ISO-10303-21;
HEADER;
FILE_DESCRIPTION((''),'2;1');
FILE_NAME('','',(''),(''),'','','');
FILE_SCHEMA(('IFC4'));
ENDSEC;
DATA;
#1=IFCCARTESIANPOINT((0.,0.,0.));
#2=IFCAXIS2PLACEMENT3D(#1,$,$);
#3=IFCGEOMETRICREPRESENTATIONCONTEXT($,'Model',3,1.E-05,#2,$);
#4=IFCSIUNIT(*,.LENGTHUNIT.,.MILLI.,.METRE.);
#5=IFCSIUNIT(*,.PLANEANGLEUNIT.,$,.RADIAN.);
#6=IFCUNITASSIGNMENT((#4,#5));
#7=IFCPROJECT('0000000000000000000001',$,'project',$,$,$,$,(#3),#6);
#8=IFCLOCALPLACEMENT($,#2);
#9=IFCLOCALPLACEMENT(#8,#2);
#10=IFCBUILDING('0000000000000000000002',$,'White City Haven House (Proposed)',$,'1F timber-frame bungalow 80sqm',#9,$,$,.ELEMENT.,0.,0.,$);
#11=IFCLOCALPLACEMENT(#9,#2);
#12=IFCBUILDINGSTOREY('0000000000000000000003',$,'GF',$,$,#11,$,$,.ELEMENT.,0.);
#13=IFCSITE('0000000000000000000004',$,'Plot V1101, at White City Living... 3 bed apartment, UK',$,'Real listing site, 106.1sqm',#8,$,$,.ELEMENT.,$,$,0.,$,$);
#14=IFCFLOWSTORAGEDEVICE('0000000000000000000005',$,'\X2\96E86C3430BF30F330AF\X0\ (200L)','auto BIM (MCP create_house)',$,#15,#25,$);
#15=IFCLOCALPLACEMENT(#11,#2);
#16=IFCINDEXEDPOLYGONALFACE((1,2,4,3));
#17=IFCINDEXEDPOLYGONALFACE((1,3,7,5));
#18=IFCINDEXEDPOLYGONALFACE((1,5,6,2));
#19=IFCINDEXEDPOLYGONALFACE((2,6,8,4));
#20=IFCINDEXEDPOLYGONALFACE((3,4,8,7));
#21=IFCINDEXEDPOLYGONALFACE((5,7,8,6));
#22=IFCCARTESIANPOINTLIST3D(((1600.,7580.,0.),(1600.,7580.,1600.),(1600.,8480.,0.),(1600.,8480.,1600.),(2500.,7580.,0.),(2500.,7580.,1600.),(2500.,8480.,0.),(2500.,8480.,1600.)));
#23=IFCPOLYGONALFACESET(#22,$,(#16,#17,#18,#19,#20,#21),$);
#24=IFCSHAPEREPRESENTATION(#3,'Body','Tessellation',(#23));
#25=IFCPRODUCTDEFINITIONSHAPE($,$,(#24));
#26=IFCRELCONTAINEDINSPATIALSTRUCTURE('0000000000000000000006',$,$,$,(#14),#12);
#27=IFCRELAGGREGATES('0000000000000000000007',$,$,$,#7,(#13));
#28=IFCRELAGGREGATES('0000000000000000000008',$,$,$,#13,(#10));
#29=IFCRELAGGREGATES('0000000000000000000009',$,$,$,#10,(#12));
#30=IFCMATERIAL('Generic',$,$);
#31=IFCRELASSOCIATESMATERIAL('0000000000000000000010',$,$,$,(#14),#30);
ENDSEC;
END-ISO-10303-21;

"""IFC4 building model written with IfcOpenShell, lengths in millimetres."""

from ifc_helpers import new_model, si_unit, frame, frame_2d, origin, place, context, project, spatial, rectangle, extrude, material, element, save


model = new_model("IFC4")

# Units and contexts
model_context = context("Model", 3, precision=1e-05, world=origin())
ifc_project = project(units=[si_unit("LENGTHUNIT", "METRE", prefix="MILLI"), si_unit("PLANEANGLEUNIT", "RADIAN")], contexts=[model_context])

# Site, building, storey
site_placement = place(None, origin())
site = spatial("IfcSite", under=ifc_project, at=site_placement, Name="Plot V1101, at White City Living... 3 bed apartment, UK", ObjectType="Real listing site, 106.1sqm", CompositionType="ELEMENT", RefElevation=0.0)
building_placement = place(site_placement, origin())
building = spatial("IfcBuilding", under=site, at=building_placement, Name="White City Haven House (Proposed)", ObjectType="1F timber-frame bungalow 80sqm", CompositionType="ELEMENT", ElevationOfRefHeight=0.0, ElevationOfTerrain=0.0)
storey_placement = place(building_placement, origin())
storey = spatial("IfcBuildingStorey", under=building, at=storey_placement, Name="GF", CompositionType="ELEMENT", Elevation=0.0)

# Flow storage device
ifc_material_1 = material(Name="Generic")
flow_storage_device_placement = place(storey_placement, frame((800.0, 3790.0, 0.0)))
element("IfcFlowStorageDevice", 1, at=flow_storage_device_placement, inside=storey, material=ifc_material_1, Name="雨水タンク (200L)", Description="auto BIM (MCP create_house)", context=model_context, shape_type="SweptSolid", body=[
    extrude(rectangle(XDim=900.0, YDim=900.0, at=frame_2d((450.0, 450.0))), frame((800.0, 3790.0, 0.0)), (0.0, 0.0, 1.0), 1600.0),
])

save(model, "model.ifc")
